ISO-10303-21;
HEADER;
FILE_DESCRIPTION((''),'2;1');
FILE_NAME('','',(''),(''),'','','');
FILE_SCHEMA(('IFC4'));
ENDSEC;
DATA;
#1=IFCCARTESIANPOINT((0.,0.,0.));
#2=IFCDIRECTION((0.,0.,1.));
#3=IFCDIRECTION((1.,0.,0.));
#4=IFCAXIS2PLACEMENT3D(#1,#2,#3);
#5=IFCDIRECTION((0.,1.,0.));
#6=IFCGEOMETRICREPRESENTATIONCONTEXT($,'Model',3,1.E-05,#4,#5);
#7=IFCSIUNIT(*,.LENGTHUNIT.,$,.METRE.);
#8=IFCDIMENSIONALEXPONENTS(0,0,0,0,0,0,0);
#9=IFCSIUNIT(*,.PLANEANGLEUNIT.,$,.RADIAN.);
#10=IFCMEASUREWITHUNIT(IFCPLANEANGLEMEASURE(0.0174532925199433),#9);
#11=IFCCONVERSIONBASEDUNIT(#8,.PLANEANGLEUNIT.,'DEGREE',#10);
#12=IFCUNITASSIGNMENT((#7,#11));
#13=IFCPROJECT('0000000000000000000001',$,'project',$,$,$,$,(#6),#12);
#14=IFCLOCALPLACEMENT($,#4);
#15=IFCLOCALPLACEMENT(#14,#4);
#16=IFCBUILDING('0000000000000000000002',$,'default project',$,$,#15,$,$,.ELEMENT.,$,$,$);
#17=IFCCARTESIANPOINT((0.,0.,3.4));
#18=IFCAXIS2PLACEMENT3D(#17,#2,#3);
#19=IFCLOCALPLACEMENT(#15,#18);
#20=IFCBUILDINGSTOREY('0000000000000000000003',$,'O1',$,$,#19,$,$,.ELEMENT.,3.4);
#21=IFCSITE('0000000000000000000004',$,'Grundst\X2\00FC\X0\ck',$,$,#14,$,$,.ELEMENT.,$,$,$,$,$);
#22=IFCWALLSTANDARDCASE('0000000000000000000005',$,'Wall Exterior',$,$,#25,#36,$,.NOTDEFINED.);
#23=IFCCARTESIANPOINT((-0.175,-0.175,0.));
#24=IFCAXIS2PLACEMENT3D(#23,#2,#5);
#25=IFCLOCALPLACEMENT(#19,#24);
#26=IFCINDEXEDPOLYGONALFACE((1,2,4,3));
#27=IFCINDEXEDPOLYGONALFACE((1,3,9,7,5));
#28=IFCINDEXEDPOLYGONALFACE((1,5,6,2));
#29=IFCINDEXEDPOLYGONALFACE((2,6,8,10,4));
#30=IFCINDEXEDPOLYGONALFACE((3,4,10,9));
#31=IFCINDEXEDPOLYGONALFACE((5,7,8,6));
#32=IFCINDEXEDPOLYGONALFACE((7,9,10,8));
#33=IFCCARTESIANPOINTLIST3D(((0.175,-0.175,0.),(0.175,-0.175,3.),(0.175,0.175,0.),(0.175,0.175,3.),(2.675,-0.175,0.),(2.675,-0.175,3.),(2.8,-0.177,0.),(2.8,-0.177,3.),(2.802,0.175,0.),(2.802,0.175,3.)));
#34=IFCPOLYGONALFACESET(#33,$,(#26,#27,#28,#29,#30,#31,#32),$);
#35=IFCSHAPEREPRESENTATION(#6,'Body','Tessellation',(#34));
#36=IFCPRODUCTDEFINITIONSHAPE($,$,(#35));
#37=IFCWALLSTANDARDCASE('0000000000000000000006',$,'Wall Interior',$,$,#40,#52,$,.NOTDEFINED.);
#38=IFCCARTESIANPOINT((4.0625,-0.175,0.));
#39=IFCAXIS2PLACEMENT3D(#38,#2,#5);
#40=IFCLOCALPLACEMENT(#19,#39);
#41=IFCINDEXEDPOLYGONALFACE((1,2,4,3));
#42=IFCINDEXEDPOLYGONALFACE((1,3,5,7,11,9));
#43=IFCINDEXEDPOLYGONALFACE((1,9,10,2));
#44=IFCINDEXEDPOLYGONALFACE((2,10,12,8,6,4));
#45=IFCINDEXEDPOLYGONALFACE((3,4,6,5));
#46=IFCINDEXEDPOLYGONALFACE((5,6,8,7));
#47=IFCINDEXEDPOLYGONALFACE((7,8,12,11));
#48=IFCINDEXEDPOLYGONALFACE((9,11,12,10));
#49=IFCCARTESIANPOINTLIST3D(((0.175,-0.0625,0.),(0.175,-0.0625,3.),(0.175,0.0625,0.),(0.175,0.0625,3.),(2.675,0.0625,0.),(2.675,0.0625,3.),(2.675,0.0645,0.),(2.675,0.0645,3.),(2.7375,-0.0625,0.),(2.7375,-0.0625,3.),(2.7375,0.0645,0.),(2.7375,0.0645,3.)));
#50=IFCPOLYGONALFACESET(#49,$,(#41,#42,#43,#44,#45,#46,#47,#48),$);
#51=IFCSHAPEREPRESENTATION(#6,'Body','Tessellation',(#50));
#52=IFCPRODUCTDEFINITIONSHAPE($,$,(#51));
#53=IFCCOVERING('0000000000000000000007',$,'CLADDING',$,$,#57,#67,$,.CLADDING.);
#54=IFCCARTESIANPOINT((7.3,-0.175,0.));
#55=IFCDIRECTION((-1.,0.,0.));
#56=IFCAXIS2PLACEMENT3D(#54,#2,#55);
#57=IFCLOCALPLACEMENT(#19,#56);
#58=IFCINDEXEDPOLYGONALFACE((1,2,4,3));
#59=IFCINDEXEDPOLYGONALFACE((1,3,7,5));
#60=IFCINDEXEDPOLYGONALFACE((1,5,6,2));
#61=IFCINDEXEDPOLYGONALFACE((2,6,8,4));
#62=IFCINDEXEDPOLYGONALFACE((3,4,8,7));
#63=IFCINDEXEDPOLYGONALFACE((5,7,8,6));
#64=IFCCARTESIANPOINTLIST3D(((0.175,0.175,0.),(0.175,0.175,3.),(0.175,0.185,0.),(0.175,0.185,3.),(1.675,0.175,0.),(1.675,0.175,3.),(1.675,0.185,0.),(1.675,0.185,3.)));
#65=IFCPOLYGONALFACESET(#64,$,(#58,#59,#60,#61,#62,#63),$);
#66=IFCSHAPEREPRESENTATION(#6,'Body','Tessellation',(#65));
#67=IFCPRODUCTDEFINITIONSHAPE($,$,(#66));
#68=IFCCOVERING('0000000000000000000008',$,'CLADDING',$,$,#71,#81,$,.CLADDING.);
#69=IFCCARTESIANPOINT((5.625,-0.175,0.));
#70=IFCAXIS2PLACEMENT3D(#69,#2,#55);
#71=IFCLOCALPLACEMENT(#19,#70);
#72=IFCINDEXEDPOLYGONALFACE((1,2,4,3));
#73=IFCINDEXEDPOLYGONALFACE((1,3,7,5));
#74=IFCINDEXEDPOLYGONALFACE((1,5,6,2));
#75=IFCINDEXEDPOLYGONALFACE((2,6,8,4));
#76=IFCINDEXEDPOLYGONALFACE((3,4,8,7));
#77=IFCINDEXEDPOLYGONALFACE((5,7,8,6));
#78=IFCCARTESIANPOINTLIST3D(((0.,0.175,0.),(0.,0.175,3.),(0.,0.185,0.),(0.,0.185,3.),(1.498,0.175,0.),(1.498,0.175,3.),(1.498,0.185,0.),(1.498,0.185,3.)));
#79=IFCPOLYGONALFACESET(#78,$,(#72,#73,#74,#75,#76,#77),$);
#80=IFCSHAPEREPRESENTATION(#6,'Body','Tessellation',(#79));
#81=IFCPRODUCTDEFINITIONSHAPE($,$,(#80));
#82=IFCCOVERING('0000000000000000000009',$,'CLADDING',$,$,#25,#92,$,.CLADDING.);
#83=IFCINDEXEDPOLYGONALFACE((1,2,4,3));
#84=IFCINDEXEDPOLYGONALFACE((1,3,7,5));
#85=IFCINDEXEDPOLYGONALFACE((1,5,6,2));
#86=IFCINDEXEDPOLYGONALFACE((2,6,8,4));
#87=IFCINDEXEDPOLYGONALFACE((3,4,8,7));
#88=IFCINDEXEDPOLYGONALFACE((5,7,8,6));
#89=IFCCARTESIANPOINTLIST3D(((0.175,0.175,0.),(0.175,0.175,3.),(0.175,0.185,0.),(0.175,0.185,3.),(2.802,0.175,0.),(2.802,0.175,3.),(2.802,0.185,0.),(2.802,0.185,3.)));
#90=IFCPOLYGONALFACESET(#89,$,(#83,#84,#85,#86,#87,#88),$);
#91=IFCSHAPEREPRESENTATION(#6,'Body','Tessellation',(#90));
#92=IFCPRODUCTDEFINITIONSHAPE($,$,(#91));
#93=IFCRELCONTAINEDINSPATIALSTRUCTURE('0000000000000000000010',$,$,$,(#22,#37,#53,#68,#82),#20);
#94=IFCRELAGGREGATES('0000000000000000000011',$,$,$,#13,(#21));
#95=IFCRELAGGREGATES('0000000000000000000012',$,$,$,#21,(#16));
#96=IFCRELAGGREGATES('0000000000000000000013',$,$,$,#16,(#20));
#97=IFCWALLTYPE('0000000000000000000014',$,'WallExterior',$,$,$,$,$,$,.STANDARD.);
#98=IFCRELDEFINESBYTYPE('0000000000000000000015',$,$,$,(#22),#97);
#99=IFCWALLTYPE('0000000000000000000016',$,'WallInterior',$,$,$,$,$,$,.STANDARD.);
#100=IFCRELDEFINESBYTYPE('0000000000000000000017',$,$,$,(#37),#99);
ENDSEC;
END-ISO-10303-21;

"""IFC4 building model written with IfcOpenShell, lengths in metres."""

from ifc_helpers import new_model, entity, si_unit, converted_unit, direction, frame, origin_with_axes, place, context, project, spatial, polyline, outline, extrude, type_object, element, save


model = new_model("IFC4")

# Units and contexts
model_context = context("Model", 3, precision=1e-05, world=origin_with_axes(), true_north=direction((0.0, 1.0, 0.0)))
ifc_project = project(units=[si_unit("LENGTHUNIT", "METRE"), converted_unit("PLANEANGLEUNIT", "DEGREE", entity("IfcPlaneAngleMeasure", 0.0174532925199433), si_unit("PLANEANGLEUNIT", "RADIAN"), dimensions=[0, 0, 0, 0, 0, 0, 0])], contexts=[model_context])

# Site, building, storey
site_placement = place(None, origin_with_axes())
site = spatial("IfcSite", under=ifc_project, at=site_placement, Name="Grundstück", CompositionType="ELEMENT")
building_placement = place(site_placement, origin_with_axes())
building = spatial("IfcBuilding", under=site, at=building_placement, Name="default project", CompositionType="ELEMENT")
placement_1 = place(building_placement, frame((0.0, 0.0, 3.4), z_axis=(0.0, 0.0, 1.0), x_axis=(1.0, 0.0, 0.0)))
storey = spatial("IfcBuildingStorey", under=building, at=placement_1, Name="O1", CompositionType="ELEMENT", Elevation=3.4)

# Walls
wall_type_1 = type_object("IfcWallType", Name="WallExterior", PredefinedType="STANDARD")
placement_2 = place(placement_1, frame((7.3, -0.175, 0.0), z_axis=(0.0, 0.0, 1.0), x_axis=(-1.0, 0.0, 0.0)))
placement_3 = place(placement_1, frame((5.625, -0.175, 0.0), z_axis=(0.0, 0.0, 1.0), x_axis=(-1.0, 0.0, 0.0)))
placement_4 = place(placement_1, frame((-0.175, -0.175, 0.0), z_axis=(0.0, 0.0, 1.0), x_axis=(0.0, 1.0, 0.0)))
element("IfcWallStandardCase", 1, at=placement_4, inside=storey, type_object=wall_type_1, Name="Wall Exterior", PredefinedType="NOTDEFINED", context=model_context, shape_type="SweptSolid", body=[
    extrude(outline(polyline([(2.802, 0.175), (0.175, 0.175), (0.175, -0.175), (2.675, -0.175), (2.8, -0.177), (2.802, 0.175)])), origin_with_axes(), (0.0, 0.0, 1.0), 3.0),
])
wall_type_2 = type_object("IfcWallType", Name="WallInterior", PredefinedType="STANDARD")
wall_1_placement = place(placement_1, frame((4.0625, -0.175, 0.0), z_axis=(0.0, 0.0, 1.0), x_axis=(0.0, 1.0, 0.0)))
element("IfcWallStandardCase", 2, at=wall_1_placement, inside=storey, type_object=wall_type_2, Name="Wall Interior", PredefinedType="NOTDEFINED", context=model_context, shape_type="SweptSolid", body=[
    extrude(outline(polyline([(2.675, 0.0625), (0.175, 0.0625), (0.175, -0.0625), (2.7375, -0.0625), (2.7375, 0.0645), (2.675, 0.0645), (2.675, 0.0625)])), origin_with_axes(), (0.0, 0.0, 1.0), 3.0),
])

# Coverings
element("IfcCovering", 3, at=placement_2, inside=storey, Name="CLADDING", PredefinedType="CLADDING", context=model_context, shape_type="SweptSolid", body=[
    extrude(outline(polyline([(1.675, 0.185), (0.175, 0.185), (0.175, 0.175), (1.675, 0.175), (1.675, 0.185)])), origin_with_axes(), (0.0, 0.0, 1.0), 3.0),
])
element("IfcCovering", 4, at=placement_3, inside=storey, Name="CLADDING", PredefinedType="CLADDING", context=model_context, shape_type="SweptSolid", body=[
    extrude(outline(polyline([(1.498, 0.185), (0.0, 0.185), (0.0, 0.175), (1.498, 0.175), (1.498, 0.185)])), origin_with_axes(), (0.0, 0.0, 1.0), 3.0),
])
element("IfcCovering", 5, at=placement_4, inside=storey, Name="CLADDING", PredefinedType="CLADDING", context=model_context, shape_type="SweptSolid", body=[
    extrude(outline(polyline([(2.802, 0.185), (0.175, 0.185), (0.175, 0.175), (2.802, 0.175), (2.802, 0.185)])), origin_with_axes(), (0.0, 0.0, 1.0), 3.0),
])

save(model, "model.ifc")
